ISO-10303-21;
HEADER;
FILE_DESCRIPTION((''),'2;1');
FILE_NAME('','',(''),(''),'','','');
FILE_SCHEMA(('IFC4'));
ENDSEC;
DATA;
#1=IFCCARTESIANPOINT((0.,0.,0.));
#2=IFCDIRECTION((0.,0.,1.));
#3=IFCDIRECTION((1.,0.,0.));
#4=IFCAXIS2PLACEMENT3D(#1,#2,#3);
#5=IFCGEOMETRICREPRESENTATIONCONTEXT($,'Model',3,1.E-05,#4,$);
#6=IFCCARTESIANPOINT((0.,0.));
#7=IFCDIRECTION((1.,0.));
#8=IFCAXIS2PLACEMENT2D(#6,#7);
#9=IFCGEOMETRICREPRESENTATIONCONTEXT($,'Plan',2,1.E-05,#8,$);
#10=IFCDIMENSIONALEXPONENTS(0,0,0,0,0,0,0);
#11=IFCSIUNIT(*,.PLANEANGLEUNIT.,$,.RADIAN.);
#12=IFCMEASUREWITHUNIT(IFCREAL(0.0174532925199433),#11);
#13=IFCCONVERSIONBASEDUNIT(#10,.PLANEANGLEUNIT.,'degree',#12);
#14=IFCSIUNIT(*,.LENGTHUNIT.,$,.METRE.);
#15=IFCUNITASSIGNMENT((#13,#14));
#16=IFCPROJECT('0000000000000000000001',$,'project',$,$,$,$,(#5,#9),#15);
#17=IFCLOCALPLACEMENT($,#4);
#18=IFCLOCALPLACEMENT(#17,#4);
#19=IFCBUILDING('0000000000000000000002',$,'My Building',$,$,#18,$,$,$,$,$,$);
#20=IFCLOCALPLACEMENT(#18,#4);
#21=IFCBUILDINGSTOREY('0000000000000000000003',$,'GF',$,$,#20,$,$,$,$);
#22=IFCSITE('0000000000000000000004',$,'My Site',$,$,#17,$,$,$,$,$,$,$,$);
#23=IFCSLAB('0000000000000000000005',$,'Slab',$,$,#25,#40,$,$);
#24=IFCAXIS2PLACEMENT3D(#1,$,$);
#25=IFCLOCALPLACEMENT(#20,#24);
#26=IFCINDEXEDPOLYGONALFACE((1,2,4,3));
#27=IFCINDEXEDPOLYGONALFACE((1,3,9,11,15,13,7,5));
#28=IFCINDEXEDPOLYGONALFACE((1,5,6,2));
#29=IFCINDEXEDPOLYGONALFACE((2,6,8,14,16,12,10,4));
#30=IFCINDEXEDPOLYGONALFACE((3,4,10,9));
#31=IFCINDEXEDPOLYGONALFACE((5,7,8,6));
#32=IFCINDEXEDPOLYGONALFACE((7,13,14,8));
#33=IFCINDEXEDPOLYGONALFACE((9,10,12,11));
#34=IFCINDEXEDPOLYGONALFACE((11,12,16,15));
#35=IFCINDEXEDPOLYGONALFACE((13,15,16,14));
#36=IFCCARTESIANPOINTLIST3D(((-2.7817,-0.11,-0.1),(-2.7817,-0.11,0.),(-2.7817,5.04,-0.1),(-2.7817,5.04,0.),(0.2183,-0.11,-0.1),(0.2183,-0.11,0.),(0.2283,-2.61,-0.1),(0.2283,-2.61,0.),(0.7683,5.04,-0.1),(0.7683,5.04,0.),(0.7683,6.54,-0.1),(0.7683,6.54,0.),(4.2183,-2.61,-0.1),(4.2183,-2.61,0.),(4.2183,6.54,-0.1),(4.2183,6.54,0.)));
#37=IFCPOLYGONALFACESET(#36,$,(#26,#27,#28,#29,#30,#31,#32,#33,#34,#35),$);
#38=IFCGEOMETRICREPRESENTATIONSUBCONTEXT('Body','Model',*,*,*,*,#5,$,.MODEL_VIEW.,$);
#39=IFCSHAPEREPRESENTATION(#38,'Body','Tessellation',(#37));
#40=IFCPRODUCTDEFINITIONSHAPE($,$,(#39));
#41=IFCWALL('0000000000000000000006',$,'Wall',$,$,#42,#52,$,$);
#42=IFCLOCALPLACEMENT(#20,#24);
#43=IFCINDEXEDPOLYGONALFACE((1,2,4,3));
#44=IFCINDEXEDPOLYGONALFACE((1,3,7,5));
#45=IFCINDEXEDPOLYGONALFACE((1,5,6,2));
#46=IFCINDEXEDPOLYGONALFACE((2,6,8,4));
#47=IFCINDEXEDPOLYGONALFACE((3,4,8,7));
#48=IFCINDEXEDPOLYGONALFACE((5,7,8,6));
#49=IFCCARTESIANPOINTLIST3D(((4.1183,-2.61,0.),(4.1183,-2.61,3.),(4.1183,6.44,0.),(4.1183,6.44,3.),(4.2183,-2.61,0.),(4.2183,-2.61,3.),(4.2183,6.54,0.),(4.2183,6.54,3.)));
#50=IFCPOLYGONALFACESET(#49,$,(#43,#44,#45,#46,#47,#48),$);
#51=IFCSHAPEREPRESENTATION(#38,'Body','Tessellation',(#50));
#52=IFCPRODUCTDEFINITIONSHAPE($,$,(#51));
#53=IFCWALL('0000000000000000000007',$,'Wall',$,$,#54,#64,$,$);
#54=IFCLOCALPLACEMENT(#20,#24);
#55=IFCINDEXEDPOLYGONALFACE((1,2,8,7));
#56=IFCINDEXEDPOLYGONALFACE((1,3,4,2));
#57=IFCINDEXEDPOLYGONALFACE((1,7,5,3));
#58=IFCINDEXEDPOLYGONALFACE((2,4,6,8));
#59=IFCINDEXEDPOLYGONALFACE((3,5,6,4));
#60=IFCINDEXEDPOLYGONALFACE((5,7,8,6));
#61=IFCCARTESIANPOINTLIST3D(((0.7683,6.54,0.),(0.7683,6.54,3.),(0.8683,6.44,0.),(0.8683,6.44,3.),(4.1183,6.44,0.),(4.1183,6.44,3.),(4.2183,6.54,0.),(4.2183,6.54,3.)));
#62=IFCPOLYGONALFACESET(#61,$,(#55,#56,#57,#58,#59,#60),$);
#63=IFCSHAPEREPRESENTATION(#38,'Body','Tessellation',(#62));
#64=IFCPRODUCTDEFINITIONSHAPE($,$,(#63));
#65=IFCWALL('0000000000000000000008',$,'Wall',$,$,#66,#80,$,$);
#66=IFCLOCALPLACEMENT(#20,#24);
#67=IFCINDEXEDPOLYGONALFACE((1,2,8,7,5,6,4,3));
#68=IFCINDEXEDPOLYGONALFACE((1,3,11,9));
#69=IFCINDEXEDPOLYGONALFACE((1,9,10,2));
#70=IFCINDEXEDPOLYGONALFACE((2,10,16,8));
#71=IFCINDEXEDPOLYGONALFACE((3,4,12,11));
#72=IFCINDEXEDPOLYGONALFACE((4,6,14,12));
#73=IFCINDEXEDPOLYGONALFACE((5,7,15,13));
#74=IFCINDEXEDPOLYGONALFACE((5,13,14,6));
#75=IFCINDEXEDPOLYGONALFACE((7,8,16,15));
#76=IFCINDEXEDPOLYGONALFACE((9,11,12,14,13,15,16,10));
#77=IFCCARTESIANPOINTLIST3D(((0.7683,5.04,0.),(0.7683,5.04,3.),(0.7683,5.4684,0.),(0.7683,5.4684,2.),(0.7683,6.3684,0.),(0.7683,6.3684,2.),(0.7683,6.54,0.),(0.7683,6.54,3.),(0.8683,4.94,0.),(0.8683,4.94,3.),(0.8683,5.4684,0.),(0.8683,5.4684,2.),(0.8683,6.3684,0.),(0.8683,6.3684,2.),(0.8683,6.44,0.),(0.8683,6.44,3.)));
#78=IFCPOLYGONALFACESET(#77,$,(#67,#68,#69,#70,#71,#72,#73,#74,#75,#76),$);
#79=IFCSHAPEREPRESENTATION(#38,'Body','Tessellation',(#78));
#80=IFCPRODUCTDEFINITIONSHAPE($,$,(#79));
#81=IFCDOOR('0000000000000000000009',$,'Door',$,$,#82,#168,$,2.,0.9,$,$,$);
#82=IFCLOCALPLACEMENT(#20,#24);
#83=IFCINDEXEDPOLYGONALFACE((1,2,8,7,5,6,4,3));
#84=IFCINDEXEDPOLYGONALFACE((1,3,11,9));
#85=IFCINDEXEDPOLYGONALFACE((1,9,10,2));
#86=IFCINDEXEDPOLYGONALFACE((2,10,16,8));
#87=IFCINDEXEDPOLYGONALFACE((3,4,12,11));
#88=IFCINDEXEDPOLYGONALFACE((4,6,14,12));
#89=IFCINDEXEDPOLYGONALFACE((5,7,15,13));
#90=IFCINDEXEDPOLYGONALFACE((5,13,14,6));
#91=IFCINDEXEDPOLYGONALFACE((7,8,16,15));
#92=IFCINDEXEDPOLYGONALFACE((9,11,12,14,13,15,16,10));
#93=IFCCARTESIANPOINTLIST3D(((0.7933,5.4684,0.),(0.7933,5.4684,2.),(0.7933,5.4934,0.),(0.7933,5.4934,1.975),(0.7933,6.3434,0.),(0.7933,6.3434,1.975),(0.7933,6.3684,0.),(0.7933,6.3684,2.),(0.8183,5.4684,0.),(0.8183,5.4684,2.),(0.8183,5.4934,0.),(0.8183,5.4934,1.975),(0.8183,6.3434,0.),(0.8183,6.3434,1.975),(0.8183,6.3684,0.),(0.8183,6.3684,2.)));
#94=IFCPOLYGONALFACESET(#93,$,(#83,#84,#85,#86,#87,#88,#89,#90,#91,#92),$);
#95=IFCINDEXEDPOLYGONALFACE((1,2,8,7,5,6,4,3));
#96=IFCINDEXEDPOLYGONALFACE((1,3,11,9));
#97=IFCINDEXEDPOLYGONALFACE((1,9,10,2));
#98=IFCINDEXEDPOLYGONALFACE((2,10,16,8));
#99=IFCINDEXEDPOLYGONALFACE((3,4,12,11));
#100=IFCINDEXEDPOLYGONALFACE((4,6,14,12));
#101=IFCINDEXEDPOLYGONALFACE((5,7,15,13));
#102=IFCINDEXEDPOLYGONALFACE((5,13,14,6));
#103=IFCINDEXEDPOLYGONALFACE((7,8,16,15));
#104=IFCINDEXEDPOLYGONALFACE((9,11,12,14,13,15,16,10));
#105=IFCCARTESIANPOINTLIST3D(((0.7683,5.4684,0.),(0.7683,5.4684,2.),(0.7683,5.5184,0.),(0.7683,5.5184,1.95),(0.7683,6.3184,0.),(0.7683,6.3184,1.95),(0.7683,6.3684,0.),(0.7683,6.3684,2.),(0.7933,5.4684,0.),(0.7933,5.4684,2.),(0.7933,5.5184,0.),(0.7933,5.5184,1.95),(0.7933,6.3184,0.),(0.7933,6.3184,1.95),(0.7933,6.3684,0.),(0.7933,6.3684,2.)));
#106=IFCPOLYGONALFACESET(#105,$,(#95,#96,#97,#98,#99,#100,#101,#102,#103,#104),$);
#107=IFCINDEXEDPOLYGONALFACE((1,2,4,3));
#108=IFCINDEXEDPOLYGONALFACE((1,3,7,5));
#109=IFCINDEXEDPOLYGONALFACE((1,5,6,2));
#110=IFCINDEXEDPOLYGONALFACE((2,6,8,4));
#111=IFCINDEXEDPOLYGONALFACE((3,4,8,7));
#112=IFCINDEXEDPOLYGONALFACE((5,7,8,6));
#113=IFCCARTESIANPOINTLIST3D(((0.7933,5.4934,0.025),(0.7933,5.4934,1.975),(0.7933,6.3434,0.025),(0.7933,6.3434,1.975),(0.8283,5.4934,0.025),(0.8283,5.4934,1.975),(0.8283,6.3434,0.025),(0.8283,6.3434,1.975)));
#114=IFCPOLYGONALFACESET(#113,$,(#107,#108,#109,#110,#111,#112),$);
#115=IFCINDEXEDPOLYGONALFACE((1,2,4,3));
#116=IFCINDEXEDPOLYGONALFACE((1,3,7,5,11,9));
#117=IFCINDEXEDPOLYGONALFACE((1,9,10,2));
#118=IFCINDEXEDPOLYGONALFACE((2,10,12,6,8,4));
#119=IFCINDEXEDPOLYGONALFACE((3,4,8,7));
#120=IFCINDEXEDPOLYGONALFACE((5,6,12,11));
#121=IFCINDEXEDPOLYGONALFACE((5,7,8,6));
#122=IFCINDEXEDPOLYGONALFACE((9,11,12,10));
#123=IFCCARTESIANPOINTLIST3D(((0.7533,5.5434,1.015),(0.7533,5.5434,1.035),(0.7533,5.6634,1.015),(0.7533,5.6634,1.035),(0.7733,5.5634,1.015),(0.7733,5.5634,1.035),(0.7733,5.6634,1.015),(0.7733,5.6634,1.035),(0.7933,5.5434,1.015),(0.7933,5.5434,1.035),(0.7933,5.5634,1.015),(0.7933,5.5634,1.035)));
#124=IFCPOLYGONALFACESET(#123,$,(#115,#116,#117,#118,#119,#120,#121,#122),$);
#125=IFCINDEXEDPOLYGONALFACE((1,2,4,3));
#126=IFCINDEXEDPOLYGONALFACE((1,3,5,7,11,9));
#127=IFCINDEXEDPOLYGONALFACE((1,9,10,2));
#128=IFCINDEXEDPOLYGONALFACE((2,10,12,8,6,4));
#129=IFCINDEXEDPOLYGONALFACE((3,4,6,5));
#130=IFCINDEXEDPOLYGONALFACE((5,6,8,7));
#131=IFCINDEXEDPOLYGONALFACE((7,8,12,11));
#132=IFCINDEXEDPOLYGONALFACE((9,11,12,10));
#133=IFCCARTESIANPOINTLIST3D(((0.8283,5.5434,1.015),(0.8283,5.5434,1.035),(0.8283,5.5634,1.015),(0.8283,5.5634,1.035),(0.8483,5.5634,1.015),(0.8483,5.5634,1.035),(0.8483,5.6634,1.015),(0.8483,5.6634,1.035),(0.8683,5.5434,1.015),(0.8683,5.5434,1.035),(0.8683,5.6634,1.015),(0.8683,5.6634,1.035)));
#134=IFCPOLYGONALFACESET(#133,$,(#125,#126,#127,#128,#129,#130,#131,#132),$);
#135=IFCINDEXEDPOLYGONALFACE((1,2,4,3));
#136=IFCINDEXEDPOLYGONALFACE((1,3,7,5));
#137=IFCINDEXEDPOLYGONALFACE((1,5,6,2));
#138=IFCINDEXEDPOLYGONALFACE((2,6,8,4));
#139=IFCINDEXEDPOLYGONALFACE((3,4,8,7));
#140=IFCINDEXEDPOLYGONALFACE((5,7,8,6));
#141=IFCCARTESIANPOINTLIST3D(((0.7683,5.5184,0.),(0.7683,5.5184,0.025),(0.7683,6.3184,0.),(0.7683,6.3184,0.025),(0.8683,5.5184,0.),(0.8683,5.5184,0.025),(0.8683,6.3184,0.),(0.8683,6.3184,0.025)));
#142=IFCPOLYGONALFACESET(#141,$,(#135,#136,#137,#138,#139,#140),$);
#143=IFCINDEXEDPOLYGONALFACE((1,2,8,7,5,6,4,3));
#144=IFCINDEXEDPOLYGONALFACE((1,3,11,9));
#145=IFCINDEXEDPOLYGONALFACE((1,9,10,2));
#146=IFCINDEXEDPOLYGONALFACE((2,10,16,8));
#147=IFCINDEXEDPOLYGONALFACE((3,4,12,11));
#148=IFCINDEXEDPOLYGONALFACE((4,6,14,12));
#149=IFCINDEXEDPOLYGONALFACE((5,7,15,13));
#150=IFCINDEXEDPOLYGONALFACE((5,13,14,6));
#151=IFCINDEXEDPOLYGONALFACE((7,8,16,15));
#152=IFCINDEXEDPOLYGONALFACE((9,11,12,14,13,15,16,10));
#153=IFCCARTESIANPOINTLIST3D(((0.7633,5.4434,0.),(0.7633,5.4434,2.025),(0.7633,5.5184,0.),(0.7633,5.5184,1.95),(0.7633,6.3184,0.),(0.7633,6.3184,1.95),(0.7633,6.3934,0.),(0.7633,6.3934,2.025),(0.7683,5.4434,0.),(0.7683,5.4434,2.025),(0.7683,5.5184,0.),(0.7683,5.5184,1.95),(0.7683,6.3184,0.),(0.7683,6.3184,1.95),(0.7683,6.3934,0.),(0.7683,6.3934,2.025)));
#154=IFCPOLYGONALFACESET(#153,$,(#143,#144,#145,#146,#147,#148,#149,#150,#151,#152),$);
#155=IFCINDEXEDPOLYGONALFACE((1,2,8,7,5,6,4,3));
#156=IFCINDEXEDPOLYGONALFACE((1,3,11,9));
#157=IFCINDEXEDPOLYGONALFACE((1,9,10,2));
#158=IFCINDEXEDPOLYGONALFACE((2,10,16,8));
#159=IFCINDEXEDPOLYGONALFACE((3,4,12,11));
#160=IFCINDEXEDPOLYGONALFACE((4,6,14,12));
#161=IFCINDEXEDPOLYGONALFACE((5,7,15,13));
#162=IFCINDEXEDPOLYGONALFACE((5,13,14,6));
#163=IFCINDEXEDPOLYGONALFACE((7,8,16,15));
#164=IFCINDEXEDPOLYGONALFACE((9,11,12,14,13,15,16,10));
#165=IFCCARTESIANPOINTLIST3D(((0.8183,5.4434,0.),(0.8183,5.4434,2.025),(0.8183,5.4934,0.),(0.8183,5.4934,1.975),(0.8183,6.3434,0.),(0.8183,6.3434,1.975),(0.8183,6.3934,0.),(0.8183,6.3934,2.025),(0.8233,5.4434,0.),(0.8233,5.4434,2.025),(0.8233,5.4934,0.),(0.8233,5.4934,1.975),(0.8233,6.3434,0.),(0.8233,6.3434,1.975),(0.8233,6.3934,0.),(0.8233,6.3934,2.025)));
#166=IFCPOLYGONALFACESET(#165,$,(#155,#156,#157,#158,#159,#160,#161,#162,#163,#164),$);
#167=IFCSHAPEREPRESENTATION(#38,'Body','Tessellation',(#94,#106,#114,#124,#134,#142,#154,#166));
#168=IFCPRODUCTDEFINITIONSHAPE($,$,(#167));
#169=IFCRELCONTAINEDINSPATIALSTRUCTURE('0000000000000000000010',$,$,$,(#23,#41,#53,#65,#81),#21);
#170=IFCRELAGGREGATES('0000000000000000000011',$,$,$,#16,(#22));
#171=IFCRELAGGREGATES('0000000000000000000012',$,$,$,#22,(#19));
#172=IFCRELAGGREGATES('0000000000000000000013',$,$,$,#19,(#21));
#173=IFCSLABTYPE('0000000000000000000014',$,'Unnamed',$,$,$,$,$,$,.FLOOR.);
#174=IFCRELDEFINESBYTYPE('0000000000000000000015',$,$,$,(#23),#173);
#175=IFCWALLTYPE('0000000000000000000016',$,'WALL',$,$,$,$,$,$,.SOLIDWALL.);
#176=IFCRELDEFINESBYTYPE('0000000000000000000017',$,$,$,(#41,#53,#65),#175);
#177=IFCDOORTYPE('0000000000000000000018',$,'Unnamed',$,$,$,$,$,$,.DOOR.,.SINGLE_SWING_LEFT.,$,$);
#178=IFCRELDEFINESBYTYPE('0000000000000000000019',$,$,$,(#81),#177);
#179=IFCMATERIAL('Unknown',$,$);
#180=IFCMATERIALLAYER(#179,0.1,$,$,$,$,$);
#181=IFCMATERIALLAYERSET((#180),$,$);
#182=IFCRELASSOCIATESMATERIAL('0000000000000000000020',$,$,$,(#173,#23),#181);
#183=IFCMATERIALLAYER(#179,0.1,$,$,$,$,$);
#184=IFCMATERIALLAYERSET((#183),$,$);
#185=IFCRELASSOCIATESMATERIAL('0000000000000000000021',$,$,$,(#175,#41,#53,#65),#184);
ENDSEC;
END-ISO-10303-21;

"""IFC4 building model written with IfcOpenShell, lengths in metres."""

from ifc_helpers import new_model, entity, si_unit, converted_unit, frame, origin_with_axes, origin_2d_with_axis, place, context, subcontext, project, spatial, line, indexed_curve, outline, extrude, shape, source, transform, mapped, material, layer, layer_set, layer_usage, type_object, type_shapes, element, fill, save


model = new_model("IFC4")

# Units and contexts
model_context = context("Model", 3, precision=1e-05, world=origin_with_axes())
plan_context = context("Plan", 2, precision=1e-05, world=origin_2d_with_axis())
body_context_1 = subcontext(model_context, "Body", "Model", "MODEL_VIEW")
body_context_2 = subcontext(plan_context, "Body", "Plan", "PLAN_VIEW")
ifc_project = project(units=[converted_unit("PLANEANGLEUNIT", "degree", entity("IfcReal", 0.0174532925199433), si_unit("PLANEANGLEUNIT", "RADIAN"), dimensions=[0, 0, 0, 0, 0, 0, 0]), si_unit("LENGTHUNIT", "METRE")], contexts=[model_context, plan_context])

# Site, building, storey
site_placement = place(None, origin_with_axes())
site = spatial("IfcSite", under=ifc_project, at=site_placement, Name="My Site")
building_placement = place(site_placement, origin_with_axes())
building = spatial("IfcBuilding", under=site, at=building_placement, Name="My Building")
storey_placement = place(building_placement, origin_with_axes())
storey = spatial("IfcBuildingStorey", under=building, at=storey_placement, Name="GF")

# Slab
ifc_material = material(Name="Unknown")
ifc_layer_1 = layer(ifc_material, 0.1)
ifc_layer_set_1 = layer_set([ifc_layer_1])
ifc_layer_usage_1 = layer_usage(ifc_layer_set_1, "AXIS3", "POSITIVE", -0.1)
slab_type = type_object("IfcSlabType", Name="Unnamed", PredefinedType="FLOOR", material=ifc_layer_set_1)
slab_placement = place(storey_placement, frame((4.2183, -2.61, 0.0), z_axis=(0.0, 0.0, 1.0), x_axis=(1.0, 0.0, 0.0)))
element("IfcSlab", 1, at=slab_placement, inside=storey, type_object=slab_type, material=ifc_layer_usage_1, Name="Slab", context=body_context_1, shape_type="SweptSolid", body=[
    extrude(outline(indexed_curve([(0.0, 0.0), (0.0, 9.15), (-3.45, 9.15), (-3.45, 7.65), (-7.0, 7.65), (-7.0, 2.5), (-4.0, 2.5), (-3.99, 0.0), (0.0, 0.0)])), frame((0.0, 0.0, -0.1), z_axis=(0.0, 0.0, 1.0), x_axis=(1.0, 0.0, 0.0)), (0.0, 0.0, 1.0), 0.1),
])

# Shared definitions
ifc_layer_2 = layer(ifc_material, 0.1)
ifc_layer_set_2 = layer_set([ifc_layer_2])
wall_type = type_object("IfcWallType", Name="WALL", PredefinedType="SOLIDWALL", material=ifc_layer_set_2)
shared_shape_1 = source(origin_with_axes(), body_context_1, "Body", "SweptSolid", [
    extrude(outline(indexed_curve([(0.0, 0.0), (0.9, 0.0), (0.9, 2.0), (0.0, 2.0)], segments=[line(1, 2, 3, 4, 1)])), frame((0.0, -0.6, 0.0), z_axis=(0.0, -1.0, 0.0), x_axis=(1.0, 0.0, 0.0)), (0.0, 0.0, -1.0), 1.2),
])
door_type = type_object("IfcDoorType", Name="Unnamed", OperationType="SINGLE_SWING_LEFT", PredefinedType="DOOR")
shared_shape_2 = source(origin_with_axes(), body_context_1, "Body", "SweptSolid", [
    extrude(outline(indexed_curve([(0.0, 0.0), (0.0, 2.0), (0.9, 2.0), (0.9, 0.0), (0.875, 0.0), (0.875, 1.975), (0.025, 1.975), (0.025, 0.0)], segments=[line(1, 2, 3, 4, 5, 6, 7, 8, 1)])), frame((0.0, 0.025, 0.0), z_axis=(0.0, -1.0, 0.0), x_axis=(1.0, 0.0, 0.0)), (0.0, 0.0, -1.0), 0.025),
    extrude(outline(indexed_curve([(0.0, 0.0), (0.0, 2.0), (0.9, 2.0), (0.9, 0.0), (0.85, 0.0), (0.85, 1.95), (0.05, 1.95), (0.05, 0.0)], segments=[line(1, 2, 3, 4, 5, 6, 7, 8, 1)])), frame((0.0, 0.0, 0.0), z_axis=(0.0, -1.0, 0.0), x_axis=(1.0, 0.0, 0.0)), (0.0, 0.0, -1.0), 0.025),
    extrude(outline(indexed_curve([(0.0, 0.0), (0.85, 0.0), (0.85, 0.035), (0.0, 0.035)], segments=[line(1, 2, 3, 4, 1)])), frame((0.025, 0.025, 0.025), z_axis=(0.0, 0.0, 1.0), x_axis=(1.0, 0.0, 0.0)), (0.0, 0.0, 1.0), 1.95),
    extrude(outline(indexed_curve([(0.0, 0.0), (0.0, -0.04), (-0.12, -0.04), (-0.12, -0.02), (-0.02, -0.02), (-0.02, 0.0)], segments=[line(1, 2, 3, 4, 5, 6, 1)])), frame((0.825, 0.025, 1.015), z_axis=(0.0, 0.0, 1.0), x_axis=(1.0, 0.0, 0.0)), (0.0, 0.0, 1.0), 0.02),
    extrude(outline(indexed_curve([(0.0, 0.0), (0.0, 0.04), (-0.12, 0.04), (-0.12, 0.02), (-0.02, 0.02), (-0.02, 0.0)], segments=[line(1, 2, 3, 4, 5, 6, 1)])), frame((0.825, 0.06, 1.015), z_axis=(0.0, 0.0, 1.0), x_axis=(1.0, 0.0, 0.0)), (0.0, 0.0, 1.0), 0.02),
    extrude(outline(indexed_curve([(0.0, 0.0), (0.8, 0.0), (0.8, 0.1), (0.0, 0.1)], segments=[line(1, 2, 3, 4, 1)])), frame((0.05, 0.0, 0.0), z_axis=(0.0, 0.0, 1.0), x_axis=(1.0, 0.0, 0.0)), (0.0, 0.0, 1.0), 0.025),
    extrude(outline(indexed_curve([(0.0, 0.0), (0.0, 2.025), (0.95, 2.025), (0.95, 0.0), (0.875, 0.0), (0.875, 1.95), (0.075, 1.95), (0.075, 0.0)], segments=[line(1, 2, 3, 4, 5, 6, 7, 8, 1)])), frame((-0.025, -0.005, 0.0), z_axis=(0.0, -1.0, 0.0), x_axis=(1.0, 0.0, 0.0)), (0.0, 0.0, -1.0), 0.005),
    extrude(outline(indexed_curve([(0.0, 0.0), (0.0, 2.025), (0.95, 2.025), (0.95, 0.0), (0.9, 0.0), (0.9, 1.975), (0.05, 1.975), (0.05, 0.0)], segments=[line(1, 2, 3, 4, 5, 6, 7, 8, 1)])), frame((-0.025, 0.05, 0.0), z_axis=(0.0, -1.0, 0.0), x_axis=(1.0, 0.0, 0.0)), (0.0, 0.0, -1.0), 0.005),
])
shared_shape_3 = source(origin_with_axes(), body_context_2, "Body", "Curve2D", [
    entity("IfcIndexedPolyCurve", entity("IfcCartesianPointList2D", [[0.0, 0.0], [0.0, 0.05], [0.025, 0.05], [0.025, 0.025], [0.05, 0.025], [0.05, 0.0]]), [entity("IfcLineIndex", [1, 2, 3, 4, 5, 6, 1])]),
    entity("IfcIndexedPolyCurve", entity("IfcCartesianPointList2D", [[0.9, 0.0], [0.9, 0.05], [0.875, 0.05], [0.875, 0.025], [0.85, 0.025], [0.85, 0.0]]), [entity("IfcLineIndex", [1, 2, 3, 4, 5, 6, 1])]),
    entity("IfcTrimmedCurve", entity("IfcEllipse", entity("IfcAxis2Placement2D", entity("IfcCartesianPoint", [0.06, 0.05]), entity("IfcDirection", [1.0, 0.0])), 0.815, 0.85), [entity("IfcCartesianPoint", [0.875, 0.05])], [entity("IfcCartesianPoint", [0.06, 0.9])], True, "CARTESIAN"),
    entity("IfcIndexedPolyCurve", entity("IfcCartesianPointList2D", [[0.025, 0.05], [0.06, 0.05], [0.06, 0.9], [0.025, 0.9]]), [entity("IfcLineIndex", [1, 2, 3, 4, 1])]),
])
type_shapes(door_type, [shared_shape_2, shared_shape_3])

# Walls
ifc_layer_usage_2 = layer_usage(ifc_layer_set_2, "AXIS2", "POSITIVE", 0.0)
wall_1_placement = place(storey_placement, frame((4.2183, -2.61, 0.0), z_axis=(0.0, 0.0, 1.0), x_axis=(0.0, 1.0, 0.0)))
element("IfcWall", 2, at=wall_1_placement, inside=storey, type_object=wall_type, material=ifc_layer_usage_2, Name="Wall", context=body_context_1, shape_type="SweptSolid", body=[
    extrude(outline(indexed_curve([(0.0, 0.0), (0.0, 0.1), (9.05, 0.1), (9.15, 0.0)], segments=[line(1, 2, 3, 4, 1)])), origin_with_axes(), (0.0, 0.0, 1.0), 3.0),
])
ifc_layer_usage_3 = layer_usage(ifc_layer_set_2, "AXIS2", "POSITIVE", 0.0)
wall_2_placement = place(storey_placement, frame((4.2183, 6.54, 0.0), z_axis=(0.0, 0.0, 1.0), x_axis=(-1.0, 0.0, 0.0)))
element("IfcWall", 3, at=wall_2_placement, inside=storey, type_object=wall_type, material=ifc_layer_usage_3, Name="Wall", context=body_context_1, shape_type="SweptSolid", body=[
    extrude(outline(indexed_curve([(0.0, 0.0), (0.1, 0.1), (3.35, 0.1), (3.45, 0.0)], segments=[line(1, 2, 3, 4, 1)])), origin_with_axes(), (0.0, 0.0, 1.0), 3.0),
])

# Wall, opening, door
ifc_layer_usage_4 = layer_usage(ifc_layer_set_2, "AXIS2", "POSITIVE", 0.0)
wall_3_placement = place(storey_placement, frame((0.7683, 6.54, 0.0), z_axis=(0.0, 0.0, 1.0), x_axis=(0.0, -1.0, 0.0)))
wall_3 = element("IfcWall", 4, at=wall_3_placement, inside=storey, type_object=wall_type, material=ifc_layer_usage_4, Name="Wall", context=body_context_1, shape_type="SweptSolid", body=[
    extrude(outline(indexed_curve([(0.0, 0.0), (0.1, 0.1), (1.6, 0.1), (1.5, 0.0)], segments=[line(1, 2, 3, 4, 1)])), origin_with_axes(), (0.0, 0.0, 1.0), 3.0),
])
opening_1_placement = place(wall_3_placement, frame((0.1715, 0.0, 0.0), z_axis=(0.0, 0.0, 1.0), x_axis=(1.0, 0.0, 0.0)))
opening_1 = element("IfcOpeningElement", 5, at=opening_1_placement, cuts=wall_3, PredefinedType="OPENING", context=body_context_1, shape_type="MappedRepresentation", body=[
    mapped(shared_shape_1, transform((0.0, 0.0, 0.0), x_axis=(1.0, 0.0, 0.0), y_axis=(0.0, 1.0, 0.0), z_axis=(0.0, 0.0, 1.0), scale=1.0)),
])
door_1_placement = place(opening_1_placement, frame((0.0, 0.0, 0.0), z_axis=(0.0, 0.0, 1.0), x_axis=(1.0, 0.0, 0.0)))
door_1 = element("IfcDoor", 6, at=door_1_placement, inside=storey, type_object=door_type, Name="Door", OverallHeight=2.0, OverallWidth=0.9, shapes=[
    shape(body_context_1, "Body", "MappedRepresentation", [mapped(shared_shape_2, transform((0.0, 0.0, 0.0), x_axis=(1.0, 0.0, 0.0), y_axis=(0.0, 1.0, 0.0), z_axis=(0.0, 0.0, 1.0), scale=1.0))]),
    shape(body_context_2, "Body", "MappedRepresentation", [mapped(shared_shape_3, transform((0.0, 0.0, 0.0), x_axis=(1.0, 0.0, 0.0), y_axis=(0.0, 1.0, 0.0), z_axis=(0.0, 0.0, 1.0), scale=1.0))]),
])
fill(opening_1, door_1)

save(model, "model.ifc")
